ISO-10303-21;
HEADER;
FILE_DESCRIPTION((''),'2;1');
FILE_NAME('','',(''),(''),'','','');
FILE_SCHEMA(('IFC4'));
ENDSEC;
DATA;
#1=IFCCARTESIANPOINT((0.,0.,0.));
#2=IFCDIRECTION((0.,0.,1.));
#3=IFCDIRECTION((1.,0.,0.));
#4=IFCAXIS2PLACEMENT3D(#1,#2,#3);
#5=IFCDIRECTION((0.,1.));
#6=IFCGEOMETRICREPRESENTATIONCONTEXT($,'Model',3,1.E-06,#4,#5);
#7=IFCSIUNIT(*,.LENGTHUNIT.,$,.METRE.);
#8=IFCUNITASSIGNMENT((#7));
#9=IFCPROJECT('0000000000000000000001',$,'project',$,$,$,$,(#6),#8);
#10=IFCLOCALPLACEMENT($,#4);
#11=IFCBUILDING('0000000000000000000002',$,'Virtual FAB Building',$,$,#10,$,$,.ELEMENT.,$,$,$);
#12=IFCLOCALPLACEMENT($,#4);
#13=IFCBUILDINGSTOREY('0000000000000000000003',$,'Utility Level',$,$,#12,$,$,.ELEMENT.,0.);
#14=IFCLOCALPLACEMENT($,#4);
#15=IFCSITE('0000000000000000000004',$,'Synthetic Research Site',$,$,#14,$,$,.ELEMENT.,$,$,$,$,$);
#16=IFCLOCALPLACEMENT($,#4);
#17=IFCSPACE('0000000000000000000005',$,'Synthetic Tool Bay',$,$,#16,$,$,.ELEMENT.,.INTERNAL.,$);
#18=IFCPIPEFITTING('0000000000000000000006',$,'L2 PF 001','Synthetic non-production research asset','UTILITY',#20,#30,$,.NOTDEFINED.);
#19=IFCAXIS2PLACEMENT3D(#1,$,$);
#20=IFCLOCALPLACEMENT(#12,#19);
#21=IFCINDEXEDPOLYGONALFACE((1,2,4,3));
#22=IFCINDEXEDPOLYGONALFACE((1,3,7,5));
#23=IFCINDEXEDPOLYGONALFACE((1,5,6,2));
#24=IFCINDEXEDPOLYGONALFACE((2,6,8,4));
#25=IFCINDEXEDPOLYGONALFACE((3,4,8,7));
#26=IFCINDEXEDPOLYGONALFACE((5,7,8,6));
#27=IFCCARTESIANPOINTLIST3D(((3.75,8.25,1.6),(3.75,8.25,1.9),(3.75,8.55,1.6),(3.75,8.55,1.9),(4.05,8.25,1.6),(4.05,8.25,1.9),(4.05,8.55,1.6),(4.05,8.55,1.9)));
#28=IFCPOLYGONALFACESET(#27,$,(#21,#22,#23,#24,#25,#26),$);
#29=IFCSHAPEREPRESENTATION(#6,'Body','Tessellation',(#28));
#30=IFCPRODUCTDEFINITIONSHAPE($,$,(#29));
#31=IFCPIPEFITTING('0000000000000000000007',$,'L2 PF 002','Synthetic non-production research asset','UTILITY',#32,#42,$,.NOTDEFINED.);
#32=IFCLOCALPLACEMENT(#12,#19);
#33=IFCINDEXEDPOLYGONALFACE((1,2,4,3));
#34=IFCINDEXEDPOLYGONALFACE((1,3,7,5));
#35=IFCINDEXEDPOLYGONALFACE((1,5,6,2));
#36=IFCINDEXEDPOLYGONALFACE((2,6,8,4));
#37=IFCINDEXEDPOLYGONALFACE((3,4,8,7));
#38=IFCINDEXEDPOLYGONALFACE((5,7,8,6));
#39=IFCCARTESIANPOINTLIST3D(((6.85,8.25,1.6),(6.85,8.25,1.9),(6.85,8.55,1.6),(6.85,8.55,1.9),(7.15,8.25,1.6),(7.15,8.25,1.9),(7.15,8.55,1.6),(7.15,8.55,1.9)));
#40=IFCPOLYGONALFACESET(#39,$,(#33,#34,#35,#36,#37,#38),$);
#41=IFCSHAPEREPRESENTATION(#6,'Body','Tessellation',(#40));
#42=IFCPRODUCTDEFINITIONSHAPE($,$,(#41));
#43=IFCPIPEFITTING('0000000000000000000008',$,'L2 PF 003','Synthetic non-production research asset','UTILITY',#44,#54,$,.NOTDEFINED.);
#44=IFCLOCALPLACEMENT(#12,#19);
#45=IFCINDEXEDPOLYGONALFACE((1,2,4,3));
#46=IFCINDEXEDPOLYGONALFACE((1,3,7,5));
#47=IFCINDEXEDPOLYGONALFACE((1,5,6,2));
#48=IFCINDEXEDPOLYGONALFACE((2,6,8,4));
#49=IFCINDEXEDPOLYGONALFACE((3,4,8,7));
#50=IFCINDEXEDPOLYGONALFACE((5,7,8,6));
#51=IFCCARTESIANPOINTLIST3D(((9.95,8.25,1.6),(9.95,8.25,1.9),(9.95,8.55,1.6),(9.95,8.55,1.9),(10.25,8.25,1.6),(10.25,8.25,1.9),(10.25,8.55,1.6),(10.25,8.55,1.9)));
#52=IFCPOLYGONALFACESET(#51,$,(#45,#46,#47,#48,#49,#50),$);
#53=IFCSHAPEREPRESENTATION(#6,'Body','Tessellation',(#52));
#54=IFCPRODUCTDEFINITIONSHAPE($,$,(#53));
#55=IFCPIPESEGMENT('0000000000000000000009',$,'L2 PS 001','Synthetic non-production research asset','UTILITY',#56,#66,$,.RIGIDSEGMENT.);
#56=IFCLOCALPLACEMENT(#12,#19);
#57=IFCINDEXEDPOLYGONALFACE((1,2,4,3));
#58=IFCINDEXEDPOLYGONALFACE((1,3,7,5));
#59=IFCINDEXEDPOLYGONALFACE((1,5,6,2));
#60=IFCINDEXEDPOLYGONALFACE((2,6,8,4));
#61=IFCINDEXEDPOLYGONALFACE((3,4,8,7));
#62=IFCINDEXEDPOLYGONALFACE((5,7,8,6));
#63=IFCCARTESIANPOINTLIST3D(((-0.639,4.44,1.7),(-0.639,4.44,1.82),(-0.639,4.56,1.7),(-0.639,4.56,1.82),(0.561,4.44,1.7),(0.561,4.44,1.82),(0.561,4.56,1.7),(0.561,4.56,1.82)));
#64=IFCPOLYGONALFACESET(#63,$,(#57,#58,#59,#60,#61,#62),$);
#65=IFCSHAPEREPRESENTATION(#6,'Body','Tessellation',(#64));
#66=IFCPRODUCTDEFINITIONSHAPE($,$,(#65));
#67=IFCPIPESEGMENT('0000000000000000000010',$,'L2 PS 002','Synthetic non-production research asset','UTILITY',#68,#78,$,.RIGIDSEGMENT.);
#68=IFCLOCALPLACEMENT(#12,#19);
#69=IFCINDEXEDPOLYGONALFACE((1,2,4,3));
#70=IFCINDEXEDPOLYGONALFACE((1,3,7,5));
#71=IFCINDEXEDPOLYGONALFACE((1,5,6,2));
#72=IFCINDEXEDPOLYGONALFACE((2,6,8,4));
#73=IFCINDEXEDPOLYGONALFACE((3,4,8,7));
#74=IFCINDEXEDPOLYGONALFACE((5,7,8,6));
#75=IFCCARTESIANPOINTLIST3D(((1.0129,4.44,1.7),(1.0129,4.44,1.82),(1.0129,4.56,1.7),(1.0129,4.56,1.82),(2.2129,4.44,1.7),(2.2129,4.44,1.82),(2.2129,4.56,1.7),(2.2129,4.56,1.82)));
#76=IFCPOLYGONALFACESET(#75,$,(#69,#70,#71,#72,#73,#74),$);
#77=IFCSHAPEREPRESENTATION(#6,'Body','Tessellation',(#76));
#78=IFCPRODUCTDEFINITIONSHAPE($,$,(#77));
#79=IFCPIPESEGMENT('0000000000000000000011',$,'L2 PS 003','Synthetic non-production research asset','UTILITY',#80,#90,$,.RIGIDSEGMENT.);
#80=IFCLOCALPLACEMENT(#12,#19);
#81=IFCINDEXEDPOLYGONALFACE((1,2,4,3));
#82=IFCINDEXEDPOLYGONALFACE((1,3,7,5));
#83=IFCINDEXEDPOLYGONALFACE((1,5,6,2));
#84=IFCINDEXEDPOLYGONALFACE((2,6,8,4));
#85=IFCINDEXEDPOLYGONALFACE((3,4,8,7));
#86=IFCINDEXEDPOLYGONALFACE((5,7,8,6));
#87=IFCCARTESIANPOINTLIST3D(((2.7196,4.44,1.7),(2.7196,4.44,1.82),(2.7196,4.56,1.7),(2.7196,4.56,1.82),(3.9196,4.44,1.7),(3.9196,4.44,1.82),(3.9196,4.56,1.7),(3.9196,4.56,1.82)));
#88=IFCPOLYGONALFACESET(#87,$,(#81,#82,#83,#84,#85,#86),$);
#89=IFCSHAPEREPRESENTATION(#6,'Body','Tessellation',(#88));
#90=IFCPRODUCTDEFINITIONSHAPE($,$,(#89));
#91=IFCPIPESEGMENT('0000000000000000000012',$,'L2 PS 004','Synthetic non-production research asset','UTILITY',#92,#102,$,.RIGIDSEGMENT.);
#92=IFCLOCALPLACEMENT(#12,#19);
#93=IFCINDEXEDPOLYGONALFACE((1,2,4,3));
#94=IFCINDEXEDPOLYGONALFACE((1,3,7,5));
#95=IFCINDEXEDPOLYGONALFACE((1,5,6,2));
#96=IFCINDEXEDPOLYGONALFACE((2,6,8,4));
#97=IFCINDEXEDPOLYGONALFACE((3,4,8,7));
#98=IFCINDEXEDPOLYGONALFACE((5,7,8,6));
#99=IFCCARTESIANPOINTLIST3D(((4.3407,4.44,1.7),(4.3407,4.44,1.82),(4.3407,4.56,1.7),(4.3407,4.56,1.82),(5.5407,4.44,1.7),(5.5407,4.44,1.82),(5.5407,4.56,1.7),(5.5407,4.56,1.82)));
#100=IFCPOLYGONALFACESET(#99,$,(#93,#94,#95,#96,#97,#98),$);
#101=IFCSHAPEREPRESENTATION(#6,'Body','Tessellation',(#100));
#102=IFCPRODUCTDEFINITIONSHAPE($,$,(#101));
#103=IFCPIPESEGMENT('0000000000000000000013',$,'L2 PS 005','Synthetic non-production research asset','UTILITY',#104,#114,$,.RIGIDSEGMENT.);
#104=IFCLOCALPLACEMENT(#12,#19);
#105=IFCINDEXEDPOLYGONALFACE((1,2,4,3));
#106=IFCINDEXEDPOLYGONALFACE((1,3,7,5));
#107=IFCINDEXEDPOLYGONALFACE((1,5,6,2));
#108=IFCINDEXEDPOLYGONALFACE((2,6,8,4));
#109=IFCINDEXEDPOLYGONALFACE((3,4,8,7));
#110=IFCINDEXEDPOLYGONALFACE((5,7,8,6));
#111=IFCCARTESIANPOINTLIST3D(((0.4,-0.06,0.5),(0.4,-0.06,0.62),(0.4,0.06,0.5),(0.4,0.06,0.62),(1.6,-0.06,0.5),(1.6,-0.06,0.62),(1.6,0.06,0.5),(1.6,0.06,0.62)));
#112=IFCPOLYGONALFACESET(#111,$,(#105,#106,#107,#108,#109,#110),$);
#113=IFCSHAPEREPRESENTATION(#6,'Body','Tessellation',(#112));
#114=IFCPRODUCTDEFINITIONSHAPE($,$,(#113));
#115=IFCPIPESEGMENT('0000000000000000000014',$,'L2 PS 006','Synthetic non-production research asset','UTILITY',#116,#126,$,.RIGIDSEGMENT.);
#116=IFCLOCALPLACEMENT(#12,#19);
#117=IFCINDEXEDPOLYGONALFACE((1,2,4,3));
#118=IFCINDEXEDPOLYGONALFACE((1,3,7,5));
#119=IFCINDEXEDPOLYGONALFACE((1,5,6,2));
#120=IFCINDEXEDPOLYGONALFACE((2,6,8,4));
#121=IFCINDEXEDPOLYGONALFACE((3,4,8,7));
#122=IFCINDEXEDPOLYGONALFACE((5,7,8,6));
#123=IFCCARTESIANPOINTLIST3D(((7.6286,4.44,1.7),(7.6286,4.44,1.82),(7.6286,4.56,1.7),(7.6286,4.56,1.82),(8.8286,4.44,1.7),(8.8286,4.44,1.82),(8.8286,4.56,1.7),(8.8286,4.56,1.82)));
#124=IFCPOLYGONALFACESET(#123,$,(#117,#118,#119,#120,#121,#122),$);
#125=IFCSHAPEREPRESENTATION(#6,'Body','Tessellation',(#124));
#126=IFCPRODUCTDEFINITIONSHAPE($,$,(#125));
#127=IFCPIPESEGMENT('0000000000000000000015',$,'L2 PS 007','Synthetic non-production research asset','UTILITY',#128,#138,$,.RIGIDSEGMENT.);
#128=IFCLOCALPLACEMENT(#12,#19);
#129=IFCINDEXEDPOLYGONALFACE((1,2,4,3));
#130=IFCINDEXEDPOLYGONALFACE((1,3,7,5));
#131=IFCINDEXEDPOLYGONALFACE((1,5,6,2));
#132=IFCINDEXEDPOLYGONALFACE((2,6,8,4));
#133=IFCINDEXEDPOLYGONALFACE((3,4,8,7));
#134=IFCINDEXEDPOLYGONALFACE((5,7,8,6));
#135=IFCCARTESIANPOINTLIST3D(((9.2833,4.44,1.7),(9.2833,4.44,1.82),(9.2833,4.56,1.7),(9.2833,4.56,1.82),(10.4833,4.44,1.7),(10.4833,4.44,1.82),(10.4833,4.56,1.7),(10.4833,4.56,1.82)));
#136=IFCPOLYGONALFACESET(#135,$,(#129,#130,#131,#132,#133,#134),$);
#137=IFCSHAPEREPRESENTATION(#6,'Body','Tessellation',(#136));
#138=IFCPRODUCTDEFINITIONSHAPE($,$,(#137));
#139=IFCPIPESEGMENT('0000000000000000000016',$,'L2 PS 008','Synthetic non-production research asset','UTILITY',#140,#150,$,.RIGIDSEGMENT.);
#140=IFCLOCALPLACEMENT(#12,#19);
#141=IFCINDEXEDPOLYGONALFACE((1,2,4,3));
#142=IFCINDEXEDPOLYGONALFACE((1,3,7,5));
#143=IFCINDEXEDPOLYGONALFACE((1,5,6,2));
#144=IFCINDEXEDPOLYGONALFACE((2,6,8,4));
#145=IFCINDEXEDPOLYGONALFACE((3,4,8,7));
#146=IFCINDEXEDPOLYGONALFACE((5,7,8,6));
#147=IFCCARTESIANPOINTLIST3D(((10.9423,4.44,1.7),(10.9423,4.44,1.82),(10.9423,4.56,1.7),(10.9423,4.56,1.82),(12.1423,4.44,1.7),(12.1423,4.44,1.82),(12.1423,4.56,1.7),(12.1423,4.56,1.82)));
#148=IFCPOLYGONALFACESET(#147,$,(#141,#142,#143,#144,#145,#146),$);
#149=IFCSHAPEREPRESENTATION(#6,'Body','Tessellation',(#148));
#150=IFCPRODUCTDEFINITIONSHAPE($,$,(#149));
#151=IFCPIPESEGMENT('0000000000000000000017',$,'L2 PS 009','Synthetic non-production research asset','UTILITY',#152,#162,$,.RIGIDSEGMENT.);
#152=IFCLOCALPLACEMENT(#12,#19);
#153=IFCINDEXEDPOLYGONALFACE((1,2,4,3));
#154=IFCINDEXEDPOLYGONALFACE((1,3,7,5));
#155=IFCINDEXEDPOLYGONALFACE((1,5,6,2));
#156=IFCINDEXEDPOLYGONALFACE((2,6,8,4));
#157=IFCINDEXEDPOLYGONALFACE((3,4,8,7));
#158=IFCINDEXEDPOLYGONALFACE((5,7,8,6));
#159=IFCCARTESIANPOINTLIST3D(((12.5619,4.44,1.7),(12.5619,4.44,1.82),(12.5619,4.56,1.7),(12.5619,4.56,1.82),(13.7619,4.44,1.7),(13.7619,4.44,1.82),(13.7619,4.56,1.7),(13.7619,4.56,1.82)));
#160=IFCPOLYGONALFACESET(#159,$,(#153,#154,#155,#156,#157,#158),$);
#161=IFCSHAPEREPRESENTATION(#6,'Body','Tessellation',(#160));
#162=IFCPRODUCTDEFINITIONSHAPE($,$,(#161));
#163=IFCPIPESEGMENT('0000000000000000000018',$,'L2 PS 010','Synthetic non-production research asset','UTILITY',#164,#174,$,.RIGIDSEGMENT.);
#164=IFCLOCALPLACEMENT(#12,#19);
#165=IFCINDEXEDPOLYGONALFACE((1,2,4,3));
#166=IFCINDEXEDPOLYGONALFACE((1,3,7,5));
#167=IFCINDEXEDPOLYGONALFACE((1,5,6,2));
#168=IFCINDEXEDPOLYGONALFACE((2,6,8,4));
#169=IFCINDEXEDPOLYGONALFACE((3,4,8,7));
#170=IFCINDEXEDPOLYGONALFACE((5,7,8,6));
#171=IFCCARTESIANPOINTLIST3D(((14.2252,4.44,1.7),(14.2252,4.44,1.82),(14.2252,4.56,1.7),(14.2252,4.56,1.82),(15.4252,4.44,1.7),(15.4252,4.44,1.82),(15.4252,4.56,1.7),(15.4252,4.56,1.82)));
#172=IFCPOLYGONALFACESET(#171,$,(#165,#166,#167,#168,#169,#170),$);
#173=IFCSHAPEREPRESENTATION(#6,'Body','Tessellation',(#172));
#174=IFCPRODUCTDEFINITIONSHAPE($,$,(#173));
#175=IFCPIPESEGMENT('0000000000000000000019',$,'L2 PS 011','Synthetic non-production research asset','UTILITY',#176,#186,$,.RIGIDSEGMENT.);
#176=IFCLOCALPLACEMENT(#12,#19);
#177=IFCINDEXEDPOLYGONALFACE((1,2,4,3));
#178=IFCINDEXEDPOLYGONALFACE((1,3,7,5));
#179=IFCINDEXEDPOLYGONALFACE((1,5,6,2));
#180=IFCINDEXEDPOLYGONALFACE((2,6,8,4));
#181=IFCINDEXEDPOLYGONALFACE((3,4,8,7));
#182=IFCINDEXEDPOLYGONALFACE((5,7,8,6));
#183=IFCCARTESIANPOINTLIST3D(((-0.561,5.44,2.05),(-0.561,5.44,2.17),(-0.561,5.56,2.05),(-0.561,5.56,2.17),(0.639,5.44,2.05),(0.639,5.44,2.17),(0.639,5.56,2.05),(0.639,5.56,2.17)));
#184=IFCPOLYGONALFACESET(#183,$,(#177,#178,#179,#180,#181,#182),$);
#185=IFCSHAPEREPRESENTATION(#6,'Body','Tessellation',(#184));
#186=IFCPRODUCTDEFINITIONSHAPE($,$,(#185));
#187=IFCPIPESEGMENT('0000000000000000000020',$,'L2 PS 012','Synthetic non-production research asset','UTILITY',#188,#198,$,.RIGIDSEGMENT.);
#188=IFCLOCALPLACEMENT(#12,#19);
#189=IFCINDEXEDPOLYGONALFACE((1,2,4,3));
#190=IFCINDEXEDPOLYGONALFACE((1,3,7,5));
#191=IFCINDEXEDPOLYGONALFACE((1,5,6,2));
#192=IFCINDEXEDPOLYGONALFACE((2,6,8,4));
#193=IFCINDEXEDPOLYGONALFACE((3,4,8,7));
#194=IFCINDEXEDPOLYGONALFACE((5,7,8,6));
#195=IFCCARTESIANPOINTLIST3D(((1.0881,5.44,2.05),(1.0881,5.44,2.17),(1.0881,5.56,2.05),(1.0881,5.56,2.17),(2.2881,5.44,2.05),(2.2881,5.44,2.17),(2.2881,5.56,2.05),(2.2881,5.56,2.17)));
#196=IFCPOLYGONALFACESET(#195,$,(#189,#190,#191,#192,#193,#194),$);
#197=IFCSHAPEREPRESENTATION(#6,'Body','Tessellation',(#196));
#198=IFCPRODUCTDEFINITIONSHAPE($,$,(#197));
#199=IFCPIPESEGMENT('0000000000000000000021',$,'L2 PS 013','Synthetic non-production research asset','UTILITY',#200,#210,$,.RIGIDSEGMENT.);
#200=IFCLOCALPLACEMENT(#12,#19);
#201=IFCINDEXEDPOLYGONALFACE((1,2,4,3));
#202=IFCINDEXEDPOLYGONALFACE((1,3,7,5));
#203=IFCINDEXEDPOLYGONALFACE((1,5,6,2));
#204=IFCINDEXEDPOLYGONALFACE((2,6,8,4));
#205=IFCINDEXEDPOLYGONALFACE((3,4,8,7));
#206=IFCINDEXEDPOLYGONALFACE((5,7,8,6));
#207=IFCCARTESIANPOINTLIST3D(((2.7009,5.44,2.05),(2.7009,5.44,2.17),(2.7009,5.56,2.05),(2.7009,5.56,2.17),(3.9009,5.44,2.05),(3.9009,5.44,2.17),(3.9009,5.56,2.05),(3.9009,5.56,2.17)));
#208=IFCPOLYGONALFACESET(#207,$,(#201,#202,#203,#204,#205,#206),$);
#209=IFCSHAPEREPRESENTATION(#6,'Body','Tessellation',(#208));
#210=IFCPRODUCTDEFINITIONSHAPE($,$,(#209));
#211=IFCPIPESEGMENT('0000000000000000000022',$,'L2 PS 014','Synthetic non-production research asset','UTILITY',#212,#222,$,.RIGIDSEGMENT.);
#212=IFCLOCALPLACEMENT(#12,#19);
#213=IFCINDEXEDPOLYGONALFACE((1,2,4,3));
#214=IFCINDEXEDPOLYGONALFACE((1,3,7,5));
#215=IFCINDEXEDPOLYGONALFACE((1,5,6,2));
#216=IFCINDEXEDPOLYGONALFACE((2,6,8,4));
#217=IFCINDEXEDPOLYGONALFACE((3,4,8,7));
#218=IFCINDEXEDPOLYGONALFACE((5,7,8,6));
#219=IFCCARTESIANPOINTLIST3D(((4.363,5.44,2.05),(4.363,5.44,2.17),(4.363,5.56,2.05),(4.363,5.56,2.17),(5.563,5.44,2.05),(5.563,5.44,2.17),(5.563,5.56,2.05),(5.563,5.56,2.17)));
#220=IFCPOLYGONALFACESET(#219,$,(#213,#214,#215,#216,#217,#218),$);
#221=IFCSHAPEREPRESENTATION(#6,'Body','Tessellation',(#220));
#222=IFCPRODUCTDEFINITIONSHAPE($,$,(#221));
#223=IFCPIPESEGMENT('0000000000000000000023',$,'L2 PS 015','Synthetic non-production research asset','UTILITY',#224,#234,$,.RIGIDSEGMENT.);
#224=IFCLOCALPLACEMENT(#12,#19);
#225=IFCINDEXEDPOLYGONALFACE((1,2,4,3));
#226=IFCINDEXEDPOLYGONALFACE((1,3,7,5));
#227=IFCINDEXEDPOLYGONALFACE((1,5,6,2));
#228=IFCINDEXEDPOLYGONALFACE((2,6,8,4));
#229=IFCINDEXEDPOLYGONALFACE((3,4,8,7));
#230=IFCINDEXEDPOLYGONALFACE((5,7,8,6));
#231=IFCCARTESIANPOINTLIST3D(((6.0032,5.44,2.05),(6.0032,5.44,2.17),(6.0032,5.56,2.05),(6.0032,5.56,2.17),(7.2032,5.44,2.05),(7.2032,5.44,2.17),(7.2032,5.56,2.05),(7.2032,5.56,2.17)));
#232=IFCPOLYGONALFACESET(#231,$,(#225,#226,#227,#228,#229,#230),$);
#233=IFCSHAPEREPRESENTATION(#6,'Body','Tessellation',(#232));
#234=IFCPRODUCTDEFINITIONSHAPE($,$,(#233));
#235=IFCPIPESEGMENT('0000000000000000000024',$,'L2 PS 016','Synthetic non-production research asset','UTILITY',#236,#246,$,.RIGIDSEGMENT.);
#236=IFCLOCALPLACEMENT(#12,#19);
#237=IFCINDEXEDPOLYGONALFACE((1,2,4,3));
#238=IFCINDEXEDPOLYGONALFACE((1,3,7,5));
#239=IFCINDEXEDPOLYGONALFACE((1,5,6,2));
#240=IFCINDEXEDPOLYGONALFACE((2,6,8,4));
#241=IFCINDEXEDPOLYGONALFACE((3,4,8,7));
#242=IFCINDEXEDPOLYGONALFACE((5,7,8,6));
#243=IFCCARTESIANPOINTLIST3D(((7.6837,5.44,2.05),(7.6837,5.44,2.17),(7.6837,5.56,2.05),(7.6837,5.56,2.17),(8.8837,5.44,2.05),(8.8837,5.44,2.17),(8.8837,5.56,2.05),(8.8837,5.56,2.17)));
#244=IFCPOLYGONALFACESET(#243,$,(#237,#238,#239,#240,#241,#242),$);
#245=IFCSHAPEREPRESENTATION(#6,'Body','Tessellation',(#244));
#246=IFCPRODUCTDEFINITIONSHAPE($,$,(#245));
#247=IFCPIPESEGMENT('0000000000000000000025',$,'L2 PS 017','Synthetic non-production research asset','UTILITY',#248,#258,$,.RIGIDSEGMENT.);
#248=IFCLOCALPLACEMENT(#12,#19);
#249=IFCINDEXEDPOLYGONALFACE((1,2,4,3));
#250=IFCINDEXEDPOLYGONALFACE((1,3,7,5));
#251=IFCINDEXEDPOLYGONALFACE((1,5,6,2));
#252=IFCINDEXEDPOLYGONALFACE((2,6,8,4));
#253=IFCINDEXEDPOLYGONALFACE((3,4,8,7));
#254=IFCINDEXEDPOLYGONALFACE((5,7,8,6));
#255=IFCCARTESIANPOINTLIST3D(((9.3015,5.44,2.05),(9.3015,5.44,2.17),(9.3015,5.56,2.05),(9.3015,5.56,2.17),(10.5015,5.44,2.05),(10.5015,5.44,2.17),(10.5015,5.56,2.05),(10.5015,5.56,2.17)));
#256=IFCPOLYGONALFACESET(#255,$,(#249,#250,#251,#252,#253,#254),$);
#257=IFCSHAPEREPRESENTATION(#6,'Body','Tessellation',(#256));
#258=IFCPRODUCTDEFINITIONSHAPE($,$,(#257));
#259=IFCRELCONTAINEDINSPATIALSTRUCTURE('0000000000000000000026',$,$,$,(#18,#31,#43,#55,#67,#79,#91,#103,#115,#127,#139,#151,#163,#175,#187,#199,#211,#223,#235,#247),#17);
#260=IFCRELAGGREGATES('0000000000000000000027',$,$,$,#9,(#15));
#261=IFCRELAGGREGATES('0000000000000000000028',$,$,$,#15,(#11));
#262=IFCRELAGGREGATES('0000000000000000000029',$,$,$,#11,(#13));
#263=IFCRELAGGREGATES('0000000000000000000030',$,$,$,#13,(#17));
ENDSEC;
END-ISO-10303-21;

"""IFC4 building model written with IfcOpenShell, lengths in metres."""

from ifc_helpers import new_model, si_unit, direction, frame, origin_with_axes, origin_2d_with_axis, place, context, project, spatial, rectangle, extrude, element, save


model = new_model("IFC4")

# Units and contexts
model_context = context("Model", 3, precision=1e-06, world=origin_with_axes(), true_north=direction((0.0, 1.0)))
ifc_project = project(units=[si_unit("LENGTHUNIT", "METRE")], contexts=[model_context])

# Site, building, storey, space
site_placement = place(None, origin_with_axes())
site = spatial("IfcSite", under=ifc_project, at=site_placement, Name="Synthetic Research Site", CompositionType="ELEMENT")
building_placement = place(None, origin_with_axes())
building = spatial("IfcBuilding", under=site, at=building_placement, Name="Virtual FAB Building", CompositionType="ELEMENT")
storey_placement = place(None, origin_with_axes())
storey = spatial("IfcBuildingStorey", under=building, at=storey_placement, Name="Utility Level", CompositionType="ELEMENT", Elevation=0.0)
space_placement = place(None, origin_with_axes())
space = spatial("IfcSpace", under=storey, at=space_placement, Name="Synthetic Tool Bay", CompositionType="ELEMENT", PredefinedType="INTERNAL")

# Pipe fittings
for number, where, z_axis, x_axis, name in (
    (1, (3.9, 8.4, 1.6), (0.0, 0.0, 1.0), (1.0, 0.0, 0.0), "L2 PF 001"),
    (2, (7.0, 8.4, 1.6), (0.0, 0.0, 1.0), (1.0, 0.0, 0.0), "L2 PF 002"),
    (3, (10.1, 8.4, 1.6), (0.0, 0.0, 1.0), (1.0, 0.0, 0.0), "L2 PF 003"),
):
    element("IfcPipeFitting", number, at=place(None, frame(where, z_axis=z_axis, x_axis=x_axis)), inside=space, Name=name, Description="Synthetic non-production research asset", ObjectType="UTILITY", PredefinedType="NOTDEFINED", context=model_context, shape_type="SweptSolid", body=[
        extrude(rectangle(XDim=0.3, YDim=0.3, at=origin_2d_with_axis()), origin_with_axes(), (0.0, 0.0, 1.0), 0.3),
    ])

# Pipe segments
for number, where, z_axis, x_axis, name in (
    (4, (-0.039, 4.5, 1.7), (0.0, 0.0, 1.0), (1.0, 0.0, 0.0), "L2 PS 001"),
    (5, (1.6129, 4.5, 1.7), (0.0, 0.0, 1.0), (1.0, 0.0, 0.0), "L2 PS 002"),
    (6, (3.3196, 4.5, 1.7), (0.0, 0.0, 1.0), (1.0, 0.0, 0.0), "L2 PS 003"),
    (7, (4.9407, 4.5, 1.7), (0.0, 0.0, 1.0), (1.0, 0.0, 0.0), "L2 PS 004"),
    (8, (1.0, 0.0, 0.5), (0.0, 0.0, 1.0), (1.0, 0.0, 0.0), "L2 PS 005"),
    (9, (8.2286, 4.5, 1.7), (0.0, 0.0, 1.0), (1.0, 0.0, 0.0), "L2 PS 006"),
    (10, (9.8833, 4.5, 1.7), (0.0, 0.0, 1.0), (1.0, 0.0, 0.0), "L2 PS 007"),
    (11, (11.5423, 4.5, 1.7), (0.0, 0.0, 1.0), (1.0, 0.0, 0.0), "L2 PS 008"),
    (12, (13.1619, 4.5, 1.7), (0.0, 0.0, 1.0), (1.0, 0.0, 0.0), "L2 PS 009"),
    (13, (14.8252, 4.5, 1.7), (0.0, 0.0, 1.0), (1.0, 0.0, 0.0), "L2 PS 010"),
    (14, (0.039, 5.5, 2.05), (0.0, 0.0, 1.0), (1.0, 0.0, 0.0), "L2 PS 011"),
    (15, (1.6881, 5.5, 2.05), (0.0, 0.0, 1.0), (1.0, 0.0, 0.0), "L2 PS 012"),
    (16, (3.3009, 5.5, 2.05), (0.0, 0.0, 1.0), (1.0, 0.0, 0.0), "L2 PS 013"),
    (17, (4.963, 5.5, 2.05), (0.0, 0.0, 1.0), (1.0, 0.0, 0.0), "L2 PS 014"),
    (18, (6.6032, 5.5, 2.05), (0.0, 0.0, 1.0), (1.0, 0.0, 0.0), "L2 PS 015"),
    (19, (8.2837, 5.5, 2.05), (0.0, 0.0, 1.0), (1.0, 0.0, 0.0), "L2 PS 016"),
    (20, (9.9015, 5.5, 2.05), (0.0, 0.0, 1.0), (1.0, 0.0, 0.0), "L2 PS 017"),
):
    element("IfcPipeSegment", number, at=place(None, frame(where, z_axis=z_axis, x_axis=x_axis)), inside=space, Name=name, Description="Synthetic non-production research asset", ObjectType="UTILITY", PredefinedType="RIGIDSEGMENT", context=model_context, shape_type="SweptSolid", body=[
        extrude(rectangle(XDim=1.2, YDim=0.12, at=origin_2d_with_axis()), origin_with_axes(), (0.0, 0.0, 1.0), 0.12),
    ])

save(model, "model.ifc")
